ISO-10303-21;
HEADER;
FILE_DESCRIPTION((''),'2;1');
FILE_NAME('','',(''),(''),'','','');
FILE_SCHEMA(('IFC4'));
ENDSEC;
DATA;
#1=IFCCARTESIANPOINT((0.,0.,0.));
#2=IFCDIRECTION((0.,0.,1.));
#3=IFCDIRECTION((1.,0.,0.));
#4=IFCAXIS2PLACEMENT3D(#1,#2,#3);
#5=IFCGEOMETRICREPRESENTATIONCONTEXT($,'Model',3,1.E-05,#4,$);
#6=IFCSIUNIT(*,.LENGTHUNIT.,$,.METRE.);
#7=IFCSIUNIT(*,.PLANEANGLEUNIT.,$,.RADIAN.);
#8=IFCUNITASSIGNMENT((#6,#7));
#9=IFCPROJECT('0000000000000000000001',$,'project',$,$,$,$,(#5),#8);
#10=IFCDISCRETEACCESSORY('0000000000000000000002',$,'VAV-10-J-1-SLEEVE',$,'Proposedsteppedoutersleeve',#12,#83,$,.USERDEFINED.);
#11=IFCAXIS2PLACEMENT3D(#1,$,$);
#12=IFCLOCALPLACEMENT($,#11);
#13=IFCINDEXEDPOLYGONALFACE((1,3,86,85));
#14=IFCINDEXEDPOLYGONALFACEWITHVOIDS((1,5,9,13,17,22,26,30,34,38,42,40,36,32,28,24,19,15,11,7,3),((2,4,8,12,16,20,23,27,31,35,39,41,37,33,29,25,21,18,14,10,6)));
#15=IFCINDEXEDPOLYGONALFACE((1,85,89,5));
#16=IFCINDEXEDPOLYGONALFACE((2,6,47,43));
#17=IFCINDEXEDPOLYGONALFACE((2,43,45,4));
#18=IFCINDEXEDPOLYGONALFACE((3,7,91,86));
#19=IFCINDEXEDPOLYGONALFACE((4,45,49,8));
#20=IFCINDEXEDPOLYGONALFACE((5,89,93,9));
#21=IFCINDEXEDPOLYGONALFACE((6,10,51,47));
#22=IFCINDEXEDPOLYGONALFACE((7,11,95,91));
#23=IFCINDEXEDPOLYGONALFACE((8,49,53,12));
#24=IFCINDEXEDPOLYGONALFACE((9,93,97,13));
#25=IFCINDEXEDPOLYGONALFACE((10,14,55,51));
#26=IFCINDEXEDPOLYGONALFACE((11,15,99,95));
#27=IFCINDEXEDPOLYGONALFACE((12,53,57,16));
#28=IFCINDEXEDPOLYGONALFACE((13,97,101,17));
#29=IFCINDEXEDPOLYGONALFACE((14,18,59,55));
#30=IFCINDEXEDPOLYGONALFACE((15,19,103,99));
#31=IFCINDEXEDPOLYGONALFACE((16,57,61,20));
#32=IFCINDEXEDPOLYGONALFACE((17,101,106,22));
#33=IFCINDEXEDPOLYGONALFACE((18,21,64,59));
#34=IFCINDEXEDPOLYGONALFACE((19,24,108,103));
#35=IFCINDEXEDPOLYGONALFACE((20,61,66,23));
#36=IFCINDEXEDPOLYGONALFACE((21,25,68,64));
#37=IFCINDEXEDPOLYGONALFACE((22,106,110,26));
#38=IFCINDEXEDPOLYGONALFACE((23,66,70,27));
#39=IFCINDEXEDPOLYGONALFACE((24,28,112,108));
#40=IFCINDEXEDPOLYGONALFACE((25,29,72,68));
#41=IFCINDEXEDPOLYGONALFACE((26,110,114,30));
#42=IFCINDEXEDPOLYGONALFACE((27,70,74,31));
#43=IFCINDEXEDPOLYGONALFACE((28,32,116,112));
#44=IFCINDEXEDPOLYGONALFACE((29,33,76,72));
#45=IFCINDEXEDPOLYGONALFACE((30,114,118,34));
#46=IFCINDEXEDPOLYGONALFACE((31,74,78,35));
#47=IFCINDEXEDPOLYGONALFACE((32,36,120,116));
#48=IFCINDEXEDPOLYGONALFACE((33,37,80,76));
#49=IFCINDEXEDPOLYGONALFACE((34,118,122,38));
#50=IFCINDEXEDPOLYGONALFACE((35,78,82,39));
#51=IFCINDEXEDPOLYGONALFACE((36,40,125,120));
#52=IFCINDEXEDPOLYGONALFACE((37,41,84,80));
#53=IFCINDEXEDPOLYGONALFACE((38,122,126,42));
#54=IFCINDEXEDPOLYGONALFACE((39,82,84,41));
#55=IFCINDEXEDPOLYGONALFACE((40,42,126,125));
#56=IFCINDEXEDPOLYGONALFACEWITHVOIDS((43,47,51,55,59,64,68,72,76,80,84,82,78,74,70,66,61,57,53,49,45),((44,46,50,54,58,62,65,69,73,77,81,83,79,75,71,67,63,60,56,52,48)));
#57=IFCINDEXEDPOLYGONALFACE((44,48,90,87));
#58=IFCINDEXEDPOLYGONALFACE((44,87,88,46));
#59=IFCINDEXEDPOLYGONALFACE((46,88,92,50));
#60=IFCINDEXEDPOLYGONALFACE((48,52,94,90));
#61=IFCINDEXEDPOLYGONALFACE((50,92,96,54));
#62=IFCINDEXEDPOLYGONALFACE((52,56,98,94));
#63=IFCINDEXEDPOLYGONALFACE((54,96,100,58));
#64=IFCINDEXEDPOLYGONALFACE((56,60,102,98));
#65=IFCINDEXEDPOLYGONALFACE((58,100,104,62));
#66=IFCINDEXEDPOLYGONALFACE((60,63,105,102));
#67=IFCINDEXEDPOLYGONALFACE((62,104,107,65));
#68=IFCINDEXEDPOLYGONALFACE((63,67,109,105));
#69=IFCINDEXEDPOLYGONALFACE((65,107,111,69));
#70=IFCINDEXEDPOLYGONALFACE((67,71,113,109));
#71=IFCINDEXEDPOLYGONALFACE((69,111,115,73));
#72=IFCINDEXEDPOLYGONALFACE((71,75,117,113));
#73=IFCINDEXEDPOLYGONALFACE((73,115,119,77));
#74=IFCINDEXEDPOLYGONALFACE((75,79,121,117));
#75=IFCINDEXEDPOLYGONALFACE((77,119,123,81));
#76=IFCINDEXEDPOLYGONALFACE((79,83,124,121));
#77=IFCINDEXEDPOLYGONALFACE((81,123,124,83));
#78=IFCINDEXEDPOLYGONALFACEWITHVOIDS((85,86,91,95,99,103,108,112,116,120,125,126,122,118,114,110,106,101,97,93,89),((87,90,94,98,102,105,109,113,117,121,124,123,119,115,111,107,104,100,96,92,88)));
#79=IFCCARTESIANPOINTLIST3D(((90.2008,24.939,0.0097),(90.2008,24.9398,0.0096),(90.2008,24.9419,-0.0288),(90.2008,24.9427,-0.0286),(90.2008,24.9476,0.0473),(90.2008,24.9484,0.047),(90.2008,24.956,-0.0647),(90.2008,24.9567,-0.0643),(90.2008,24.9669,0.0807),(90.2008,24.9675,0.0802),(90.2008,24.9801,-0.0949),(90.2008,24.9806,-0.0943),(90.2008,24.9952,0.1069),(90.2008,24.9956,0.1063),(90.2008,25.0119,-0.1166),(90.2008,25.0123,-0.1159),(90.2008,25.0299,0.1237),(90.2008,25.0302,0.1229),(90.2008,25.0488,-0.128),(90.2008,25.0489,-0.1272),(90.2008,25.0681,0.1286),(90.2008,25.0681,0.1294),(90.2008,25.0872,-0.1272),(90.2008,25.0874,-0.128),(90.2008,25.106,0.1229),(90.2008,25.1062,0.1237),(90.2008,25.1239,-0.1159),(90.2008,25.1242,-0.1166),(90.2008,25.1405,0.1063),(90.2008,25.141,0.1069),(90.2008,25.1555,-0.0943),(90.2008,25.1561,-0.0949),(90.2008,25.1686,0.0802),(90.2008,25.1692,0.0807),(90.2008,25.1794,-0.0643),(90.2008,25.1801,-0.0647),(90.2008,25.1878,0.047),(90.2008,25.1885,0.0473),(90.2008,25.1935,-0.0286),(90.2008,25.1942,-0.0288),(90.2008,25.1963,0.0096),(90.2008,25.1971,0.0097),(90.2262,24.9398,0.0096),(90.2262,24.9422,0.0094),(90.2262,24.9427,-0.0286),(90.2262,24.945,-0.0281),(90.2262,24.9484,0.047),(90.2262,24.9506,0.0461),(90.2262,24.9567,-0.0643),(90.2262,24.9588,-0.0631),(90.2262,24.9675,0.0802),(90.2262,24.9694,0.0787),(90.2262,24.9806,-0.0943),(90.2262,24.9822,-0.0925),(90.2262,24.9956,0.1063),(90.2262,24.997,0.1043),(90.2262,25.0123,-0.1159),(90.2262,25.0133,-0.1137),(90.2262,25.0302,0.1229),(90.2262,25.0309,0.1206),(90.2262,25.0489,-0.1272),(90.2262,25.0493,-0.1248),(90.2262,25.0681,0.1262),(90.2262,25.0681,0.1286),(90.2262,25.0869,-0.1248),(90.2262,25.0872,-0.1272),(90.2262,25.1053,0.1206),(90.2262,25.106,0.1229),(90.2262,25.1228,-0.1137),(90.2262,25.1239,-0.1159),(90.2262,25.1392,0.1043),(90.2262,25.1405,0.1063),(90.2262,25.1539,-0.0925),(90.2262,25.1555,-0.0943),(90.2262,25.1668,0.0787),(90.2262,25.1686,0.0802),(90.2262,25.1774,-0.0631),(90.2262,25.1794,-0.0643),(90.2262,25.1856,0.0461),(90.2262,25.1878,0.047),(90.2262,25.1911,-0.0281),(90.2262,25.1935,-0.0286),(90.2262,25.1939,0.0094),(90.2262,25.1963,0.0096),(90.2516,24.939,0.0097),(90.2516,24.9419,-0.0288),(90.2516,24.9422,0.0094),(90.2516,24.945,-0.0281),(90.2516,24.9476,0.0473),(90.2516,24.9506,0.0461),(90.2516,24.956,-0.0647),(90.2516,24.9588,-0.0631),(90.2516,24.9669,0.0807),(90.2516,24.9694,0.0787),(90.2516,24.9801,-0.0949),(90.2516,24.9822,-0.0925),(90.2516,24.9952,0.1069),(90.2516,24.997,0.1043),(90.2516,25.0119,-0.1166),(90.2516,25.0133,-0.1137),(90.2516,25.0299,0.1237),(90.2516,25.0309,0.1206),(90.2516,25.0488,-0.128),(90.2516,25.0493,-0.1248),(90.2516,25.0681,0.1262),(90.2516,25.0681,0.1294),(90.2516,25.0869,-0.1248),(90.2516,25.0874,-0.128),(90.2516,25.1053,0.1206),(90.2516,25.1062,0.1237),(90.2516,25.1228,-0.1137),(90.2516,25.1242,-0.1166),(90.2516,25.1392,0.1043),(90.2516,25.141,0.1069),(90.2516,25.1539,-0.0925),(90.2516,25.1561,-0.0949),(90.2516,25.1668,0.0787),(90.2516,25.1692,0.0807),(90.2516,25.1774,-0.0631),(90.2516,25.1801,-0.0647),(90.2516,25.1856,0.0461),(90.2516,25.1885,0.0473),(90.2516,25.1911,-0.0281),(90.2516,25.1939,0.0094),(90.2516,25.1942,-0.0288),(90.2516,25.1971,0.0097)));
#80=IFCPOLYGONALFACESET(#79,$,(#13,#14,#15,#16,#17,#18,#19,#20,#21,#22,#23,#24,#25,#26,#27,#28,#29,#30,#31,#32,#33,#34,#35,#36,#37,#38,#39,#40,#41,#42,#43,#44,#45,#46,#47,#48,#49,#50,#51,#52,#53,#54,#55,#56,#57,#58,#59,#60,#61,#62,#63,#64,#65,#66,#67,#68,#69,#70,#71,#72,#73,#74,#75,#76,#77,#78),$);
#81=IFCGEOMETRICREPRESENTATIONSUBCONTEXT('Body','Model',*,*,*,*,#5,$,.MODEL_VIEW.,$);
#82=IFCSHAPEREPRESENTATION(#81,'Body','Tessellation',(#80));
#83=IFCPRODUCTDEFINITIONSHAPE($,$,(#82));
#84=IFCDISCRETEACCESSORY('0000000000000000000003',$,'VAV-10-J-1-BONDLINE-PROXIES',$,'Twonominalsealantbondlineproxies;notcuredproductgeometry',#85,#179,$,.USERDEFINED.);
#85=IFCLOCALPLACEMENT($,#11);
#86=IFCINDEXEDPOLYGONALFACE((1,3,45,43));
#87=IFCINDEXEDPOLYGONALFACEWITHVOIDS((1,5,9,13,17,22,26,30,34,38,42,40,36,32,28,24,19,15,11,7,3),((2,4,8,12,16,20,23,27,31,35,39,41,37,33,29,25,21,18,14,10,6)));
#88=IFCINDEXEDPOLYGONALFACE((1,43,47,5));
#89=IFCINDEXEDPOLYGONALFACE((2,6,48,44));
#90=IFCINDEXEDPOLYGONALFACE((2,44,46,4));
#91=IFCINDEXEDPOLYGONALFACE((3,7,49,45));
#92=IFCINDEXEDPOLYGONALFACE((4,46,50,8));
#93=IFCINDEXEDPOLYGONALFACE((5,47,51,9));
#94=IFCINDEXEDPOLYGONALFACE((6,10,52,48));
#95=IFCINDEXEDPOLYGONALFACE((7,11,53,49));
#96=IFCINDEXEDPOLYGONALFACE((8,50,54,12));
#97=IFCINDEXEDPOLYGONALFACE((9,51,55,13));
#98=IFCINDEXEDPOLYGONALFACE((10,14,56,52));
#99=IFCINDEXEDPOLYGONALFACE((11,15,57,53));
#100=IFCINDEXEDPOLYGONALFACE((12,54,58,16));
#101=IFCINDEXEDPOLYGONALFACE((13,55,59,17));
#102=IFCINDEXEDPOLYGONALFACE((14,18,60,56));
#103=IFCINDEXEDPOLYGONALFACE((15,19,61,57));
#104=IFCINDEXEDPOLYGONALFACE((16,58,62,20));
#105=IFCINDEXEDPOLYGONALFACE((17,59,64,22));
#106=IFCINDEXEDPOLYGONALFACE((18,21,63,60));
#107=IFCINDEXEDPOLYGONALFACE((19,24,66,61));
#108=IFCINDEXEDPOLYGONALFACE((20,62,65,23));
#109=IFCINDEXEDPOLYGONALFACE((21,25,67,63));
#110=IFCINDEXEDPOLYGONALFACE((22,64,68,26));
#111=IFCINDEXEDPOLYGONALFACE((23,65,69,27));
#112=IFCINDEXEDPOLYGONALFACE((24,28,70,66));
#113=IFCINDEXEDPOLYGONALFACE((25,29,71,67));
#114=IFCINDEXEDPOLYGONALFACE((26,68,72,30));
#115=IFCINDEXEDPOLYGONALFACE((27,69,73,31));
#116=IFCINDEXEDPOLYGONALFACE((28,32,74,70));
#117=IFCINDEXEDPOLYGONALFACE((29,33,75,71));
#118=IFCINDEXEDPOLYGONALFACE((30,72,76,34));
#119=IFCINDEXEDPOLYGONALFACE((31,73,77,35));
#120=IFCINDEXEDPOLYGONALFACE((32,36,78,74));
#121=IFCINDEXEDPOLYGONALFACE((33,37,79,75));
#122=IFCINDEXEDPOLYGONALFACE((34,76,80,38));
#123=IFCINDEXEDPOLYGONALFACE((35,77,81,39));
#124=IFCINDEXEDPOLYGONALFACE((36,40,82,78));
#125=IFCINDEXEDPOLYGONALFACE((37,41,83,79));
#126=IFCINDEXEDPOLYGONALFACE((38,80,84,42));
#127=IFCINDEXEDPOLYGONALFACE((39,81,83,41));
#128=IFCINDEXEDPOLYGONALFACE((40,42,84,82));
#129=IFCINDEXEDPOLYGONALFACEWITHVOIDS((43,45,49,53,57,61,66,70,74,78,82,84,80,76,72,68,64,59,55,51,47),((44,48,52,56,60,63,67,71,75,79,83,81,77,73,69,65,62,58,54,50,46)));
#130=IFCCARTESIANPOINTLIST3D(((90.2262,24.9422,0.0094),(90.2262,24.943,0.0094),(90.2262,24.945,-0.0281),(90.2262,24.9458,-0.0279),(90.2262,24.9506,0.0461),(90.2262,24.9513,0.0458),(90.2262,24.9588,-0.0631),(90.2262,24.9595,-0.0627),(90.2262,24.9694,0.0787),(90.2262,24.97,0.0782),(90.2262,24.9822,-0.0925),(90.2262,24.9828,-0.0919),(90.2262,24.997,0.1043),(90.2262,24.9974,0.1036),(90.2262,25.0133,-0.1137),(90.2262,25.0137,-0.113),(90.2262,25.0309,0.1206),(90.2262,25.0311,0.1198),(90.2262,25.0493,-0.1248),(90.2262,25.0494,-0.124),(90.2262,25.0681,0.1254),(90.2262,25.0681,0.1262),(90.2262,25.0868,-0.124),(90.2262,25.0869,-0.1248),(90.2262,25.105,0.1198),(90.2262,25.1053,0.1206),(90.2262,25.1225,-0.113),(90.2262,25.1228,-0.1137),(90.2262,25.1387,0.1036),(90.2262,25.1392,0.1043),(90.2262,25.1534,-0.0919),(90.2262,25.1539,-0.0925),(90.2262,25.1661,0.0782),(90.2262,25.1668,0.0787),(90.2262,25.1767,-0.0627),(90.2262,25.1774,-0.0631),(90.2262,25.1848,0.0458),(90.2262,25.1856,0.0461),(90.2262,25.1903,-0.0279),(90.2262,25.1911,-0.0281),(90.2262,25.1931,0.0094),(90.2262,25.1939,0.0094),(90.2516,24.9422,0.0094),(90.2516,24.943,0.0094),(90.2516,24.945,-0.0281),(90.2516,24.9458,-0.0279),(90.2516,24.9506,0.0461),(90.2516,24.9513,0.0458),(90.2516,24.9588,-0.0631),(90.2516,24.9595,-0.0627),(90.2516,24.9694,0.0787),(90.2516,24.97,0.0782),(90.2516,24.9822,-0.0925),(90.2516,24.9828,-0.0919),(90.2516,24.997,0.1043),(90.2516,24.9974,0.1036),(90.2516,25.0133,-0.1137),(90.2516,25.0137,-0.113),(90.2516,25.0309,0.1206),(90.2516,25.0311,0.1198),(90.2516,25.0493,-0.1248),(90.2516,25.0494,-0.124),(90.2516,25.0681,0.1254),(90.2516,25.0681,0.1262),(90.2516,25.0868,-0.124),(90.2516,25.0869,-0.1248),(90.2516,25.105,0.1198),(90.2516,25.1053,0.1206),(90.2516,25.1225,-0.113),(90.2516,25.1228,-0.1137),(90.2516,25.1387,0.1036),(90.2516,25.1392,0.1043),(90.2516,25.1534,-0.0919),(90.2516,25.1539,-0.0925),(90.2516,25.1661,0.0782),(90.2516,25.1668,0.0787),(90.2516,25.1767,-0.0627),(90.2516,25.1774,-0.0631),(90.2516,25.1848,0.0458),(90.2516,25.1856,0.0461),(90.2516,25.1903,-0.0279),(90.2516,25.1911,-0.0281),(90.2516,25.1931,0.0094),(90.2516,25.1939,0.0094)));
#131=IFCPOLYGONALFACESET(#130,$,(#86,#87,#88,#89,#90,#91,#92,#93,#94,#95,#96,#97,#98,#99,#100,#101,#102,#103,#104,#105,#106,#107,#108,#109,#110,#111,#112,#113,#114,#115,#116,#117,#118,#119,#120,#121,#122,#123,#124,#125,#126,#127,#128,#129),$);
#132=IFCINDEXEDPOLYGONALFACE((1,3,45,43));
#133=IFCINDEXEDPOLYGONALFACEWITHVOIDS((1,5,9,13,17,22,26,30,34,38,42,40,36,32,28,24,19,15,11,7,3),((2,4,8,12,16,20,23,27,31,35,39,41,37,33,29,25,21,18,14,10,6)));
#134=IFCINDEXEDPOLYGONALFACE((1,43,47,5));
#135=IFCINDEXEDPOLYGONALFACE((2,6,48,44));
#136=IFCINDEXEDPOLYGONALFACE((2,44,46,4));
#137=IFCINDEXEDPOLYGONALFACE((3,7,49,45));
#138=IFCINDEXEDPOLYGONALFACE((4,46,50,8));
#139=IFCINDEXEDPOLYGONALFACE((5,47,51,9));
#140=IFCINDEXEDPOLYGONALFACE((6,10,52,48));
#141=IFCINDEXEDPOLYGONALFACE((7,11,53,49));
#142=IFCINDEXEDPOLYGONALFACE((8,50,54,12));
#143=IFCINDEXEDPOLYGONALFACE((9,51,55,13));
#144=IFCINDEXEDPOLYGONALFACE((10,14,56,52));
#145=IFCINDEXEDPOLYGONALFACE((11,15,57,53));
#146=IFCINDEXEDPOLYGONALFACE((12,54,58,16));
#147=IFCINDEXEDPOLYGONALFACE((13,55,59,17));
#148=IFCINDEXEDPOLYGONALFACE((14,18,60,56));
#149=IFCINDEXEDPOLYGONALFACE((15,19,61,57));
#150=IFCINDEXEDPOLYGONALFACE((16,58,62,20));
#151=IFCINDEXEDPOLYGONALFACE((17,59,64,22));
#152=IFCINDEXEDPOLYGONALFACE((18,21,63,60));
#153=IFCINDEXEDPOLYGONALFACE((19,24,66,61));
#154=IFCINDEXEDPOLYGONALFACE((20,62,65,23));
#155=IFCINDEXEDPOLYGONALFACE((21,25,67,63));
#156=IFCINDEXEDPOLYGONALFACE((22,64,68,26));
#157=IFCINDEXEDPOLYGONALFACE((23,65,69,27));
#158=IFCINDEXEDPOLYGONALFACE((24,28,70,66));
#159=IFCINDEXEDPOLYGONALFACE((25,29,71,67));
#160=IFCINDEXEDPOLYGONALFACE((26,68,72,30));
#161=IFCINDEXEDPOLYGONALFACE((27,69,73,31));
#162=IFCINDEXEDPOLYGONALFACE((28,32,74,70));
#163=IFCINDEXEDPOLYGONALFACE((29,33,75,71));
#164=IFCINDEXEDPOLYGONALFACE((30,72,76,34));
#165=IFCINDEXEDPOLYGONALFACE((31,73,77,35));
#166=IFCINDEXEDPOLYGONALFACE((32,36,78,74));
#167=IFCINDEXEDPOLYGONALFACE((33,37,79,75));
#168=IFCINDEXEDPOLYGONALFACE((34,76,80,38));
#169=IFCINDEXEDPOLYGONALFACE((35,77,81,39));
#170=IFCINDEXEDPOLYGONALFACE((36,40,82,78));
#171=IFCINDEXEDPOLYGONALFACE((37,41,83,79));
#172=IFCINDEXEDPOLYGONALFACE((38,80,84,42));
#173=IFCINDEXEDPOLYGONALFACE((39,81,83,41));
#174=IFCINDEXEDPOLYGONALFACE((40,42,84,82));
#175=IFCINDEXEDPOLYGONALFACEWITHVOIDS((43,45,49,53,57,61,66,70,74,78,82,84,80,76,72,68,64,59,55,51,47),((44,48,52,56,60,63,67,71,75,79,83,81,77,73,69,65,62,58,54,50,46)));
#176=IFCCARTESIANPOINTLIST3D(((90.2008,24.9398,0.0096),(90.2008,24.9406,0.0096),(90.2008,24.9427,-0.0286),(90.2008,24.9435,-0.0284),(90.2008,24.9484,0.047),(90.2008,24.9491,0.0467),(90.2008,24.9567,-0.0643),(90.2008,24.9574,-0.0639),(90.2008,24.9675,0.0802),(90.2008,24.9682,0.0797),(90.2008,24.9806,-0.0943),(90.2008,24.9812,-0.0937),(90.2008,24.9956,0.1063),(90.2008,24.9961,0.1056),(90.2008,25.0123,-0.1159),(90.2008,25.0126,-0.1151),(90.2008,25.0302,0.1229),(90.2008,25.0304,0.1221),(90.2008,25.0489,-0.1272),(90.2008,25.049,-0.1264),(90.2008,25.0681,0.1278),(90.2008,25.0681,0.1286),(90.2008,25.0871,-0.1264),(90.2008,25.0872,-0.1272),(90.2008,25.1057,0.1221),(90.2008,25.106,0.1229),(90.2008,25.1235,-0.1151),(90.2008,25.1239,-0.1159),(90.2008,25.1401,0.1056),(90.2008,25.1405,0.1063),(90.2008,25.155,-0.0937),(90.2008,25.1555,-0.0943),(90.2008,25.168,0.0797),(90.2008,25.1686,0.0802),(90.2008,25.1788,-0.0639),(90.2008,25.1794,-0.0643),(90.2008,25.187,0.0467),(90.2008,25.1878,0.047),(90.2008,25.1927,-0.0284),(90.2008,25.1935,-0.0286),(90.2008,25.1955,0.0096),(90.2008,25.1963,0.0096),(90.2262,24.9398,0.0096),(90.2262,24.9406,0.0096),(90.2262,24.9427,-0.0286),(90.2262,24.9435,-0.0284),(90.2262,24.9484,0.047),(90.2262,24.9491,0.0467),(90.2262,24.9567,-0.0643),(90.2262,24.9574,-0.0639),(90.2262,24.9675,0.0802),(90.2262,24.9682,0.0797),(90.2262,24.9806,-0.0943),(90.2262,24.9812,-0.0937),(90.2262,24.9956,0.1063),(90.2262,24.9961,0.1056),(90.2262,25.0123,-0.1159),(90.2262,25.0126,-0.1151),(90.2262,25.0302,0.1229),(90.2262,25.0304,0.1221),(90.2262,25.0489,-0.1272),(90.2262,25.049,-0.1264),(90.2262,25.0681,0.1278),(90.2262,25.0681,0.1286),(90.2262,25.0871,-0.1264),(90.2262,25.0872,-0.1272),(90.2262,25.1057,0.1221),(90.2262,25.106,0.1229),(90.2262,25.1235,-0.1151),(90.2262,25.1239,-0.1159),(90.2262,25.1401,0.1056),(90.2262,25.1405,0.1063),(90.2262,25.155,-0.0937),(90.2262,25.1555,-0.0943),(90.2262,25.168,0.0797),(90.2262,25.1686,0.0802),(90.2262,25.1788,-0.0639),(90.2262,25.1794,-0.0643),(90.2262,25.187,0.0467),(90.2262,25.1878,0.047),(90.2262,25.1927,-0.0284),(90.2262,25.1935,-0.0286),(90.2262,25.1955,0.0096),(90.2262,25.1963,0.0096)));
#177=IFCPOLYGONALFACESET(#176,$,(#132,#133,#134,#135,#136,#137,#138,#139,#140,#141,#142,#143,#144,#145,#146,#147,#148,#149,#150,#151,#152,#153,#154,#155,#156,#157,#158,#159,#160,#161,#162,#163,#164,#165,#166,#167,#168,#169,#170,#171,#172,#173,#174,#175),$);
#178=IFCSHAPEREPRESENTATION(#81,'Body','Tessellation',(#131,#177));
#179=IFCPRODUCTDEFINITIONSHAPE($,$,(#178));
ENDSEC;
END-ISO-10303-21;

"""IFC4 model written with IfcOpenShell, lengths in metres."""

from ifc_helpers import new_model, entity, si_unit, frame, origin_with_axes, place, context, subcontext, project, element, save


model = new_model("IFC4")

# Units and contexts
model_context = context("Model", 3, precision=1e-05, world=origin_with_axes())
body_context = subcontext(model_context, "Body", "Model", "MODEL_VIEW")
ifc_project = project(units=[si_unit("LENGTHUNIT", "METRE"), si_unit("PLANEANGLEUNIT", "RADIAN")], contexts=[model_context])

# Discrete accessories
discrete_accessory_1_placement = place(None, frame((90.2262, 25.0681, 0.0), z_axis=(0.0, -1.0, 0.0), x_axis=(0.0, 0.0, 1.0)))
element("IfcDiscreteAccessory", 1, at=discrete_accessory_1_placement, Name="VAV-10-J-1-SLEEVE", ObjectType="Proposedsteppedoutersleeve", PredefinedType="USERDEFINED", context=body_context, shape_type="SweptSolid", body=[
    entity("IfcRevolvedAreaSolid", entity("IfcArbitraryClosedProfileDef", "AREA", None, entity("IfcPolyline", [entity("IfcCartesianPoint", [0.1262, -0.0254]), entity("IfcCartesianPoint", [0.1294, -0.0254]), entity("IfcCartesianPoint", [0.1294, 0.0254]), entity("IfcCartesianPoint", [0.1286, 0.0254]), entity("IfcCartesianPoint", [0.1286, 0.0]), entity("IfcCartesianPoint", [0.1262, 0.0]), entity("IfcCartesianPoint", [0.1262, -0.0254])])), entity("IfcAxis2Placement3D", entity("IfcCartesianPoint", [0.0, 0.0, 0.0])), entity("IfcAxis1Placement", entity("IfcCartesianPoint", [0.0, 0.0, 0.0]), entity("IfcDirection", [0.0, 1.0, 0.0])), 6.283185),
])
discrete_accessory_2_placement = place(None, frame((90.2262, 25.0681, 0.0), z_axis=(0.0, -1.0, 0.0), x_axis=(0.0, 0.0, 1.0)))
element("IfcDiscreteAccessory", 2, at=discrete_accessory_2_placement, Name="VAV-10-J-1-BONDLINE-PROXIES", ObjectType="Twonominalsealantbondlineproxies;notcuredproductgeometry", PredefinedType="USERDEFINED", context=body_context, shape_type="SweptSolid", body=[
    entity("IfcRevolvedAreaSolid", entity("IfcArbitraryClosedProfileDef", "AREA", None, entity("IfcPolyline", [entity("IfcCartesianPoint", [0.1254, -0.0254]), entity("IfcCartesianPoint", [0.1262, -0.0254]), entity("IfcCartesianPoint", [0.1262, 0.0]), entity("IfcCartesianPoint", [0.1254, 0.0]), entity("IfcCartesianPoint", [0.1254, -0.0254])])), entity("IfcAxis2Placement3D", entity("IfcCartesianPoint", [0.0, 0.0, 0.0])), entity("IfcAxis1Placement", entity("IfcCartesianPoint", [0.0, 0.0, 0.0]), entity("IfcDirection", [0.0, 1.0, 0.0])), 6.283185),
    entity("IfcRevolvedAreaSolid", entity("IfcArbitraryClosedProfileDef", "AREA", None, entity("IfcPolyline", [entity("IfcCartesianPoint", [0.1278, 0.0]), entity("IfcCartesianPoint", [0.1286, 0.0]), entity("IfcCartesianPoint", [0.1286, 0.0254]), entity("IfcCartesianPoint", [0.1278, 0.0254]), entity("IfcCartesianPoint", [0.1278, 0.0])])), entity("IfcAxis2Placement3D", entity("IfcCartesianPoint", [0.0, 0.0, 0.0])), entity("IfcAxis1Placement", entity("IfcCartesianPoint", [0.0, 0.0, 0.0]), entity("IfcDirection", [0.0, 1.0, 0.0])), 6.283185),
])

save(model, "model.ifc")
